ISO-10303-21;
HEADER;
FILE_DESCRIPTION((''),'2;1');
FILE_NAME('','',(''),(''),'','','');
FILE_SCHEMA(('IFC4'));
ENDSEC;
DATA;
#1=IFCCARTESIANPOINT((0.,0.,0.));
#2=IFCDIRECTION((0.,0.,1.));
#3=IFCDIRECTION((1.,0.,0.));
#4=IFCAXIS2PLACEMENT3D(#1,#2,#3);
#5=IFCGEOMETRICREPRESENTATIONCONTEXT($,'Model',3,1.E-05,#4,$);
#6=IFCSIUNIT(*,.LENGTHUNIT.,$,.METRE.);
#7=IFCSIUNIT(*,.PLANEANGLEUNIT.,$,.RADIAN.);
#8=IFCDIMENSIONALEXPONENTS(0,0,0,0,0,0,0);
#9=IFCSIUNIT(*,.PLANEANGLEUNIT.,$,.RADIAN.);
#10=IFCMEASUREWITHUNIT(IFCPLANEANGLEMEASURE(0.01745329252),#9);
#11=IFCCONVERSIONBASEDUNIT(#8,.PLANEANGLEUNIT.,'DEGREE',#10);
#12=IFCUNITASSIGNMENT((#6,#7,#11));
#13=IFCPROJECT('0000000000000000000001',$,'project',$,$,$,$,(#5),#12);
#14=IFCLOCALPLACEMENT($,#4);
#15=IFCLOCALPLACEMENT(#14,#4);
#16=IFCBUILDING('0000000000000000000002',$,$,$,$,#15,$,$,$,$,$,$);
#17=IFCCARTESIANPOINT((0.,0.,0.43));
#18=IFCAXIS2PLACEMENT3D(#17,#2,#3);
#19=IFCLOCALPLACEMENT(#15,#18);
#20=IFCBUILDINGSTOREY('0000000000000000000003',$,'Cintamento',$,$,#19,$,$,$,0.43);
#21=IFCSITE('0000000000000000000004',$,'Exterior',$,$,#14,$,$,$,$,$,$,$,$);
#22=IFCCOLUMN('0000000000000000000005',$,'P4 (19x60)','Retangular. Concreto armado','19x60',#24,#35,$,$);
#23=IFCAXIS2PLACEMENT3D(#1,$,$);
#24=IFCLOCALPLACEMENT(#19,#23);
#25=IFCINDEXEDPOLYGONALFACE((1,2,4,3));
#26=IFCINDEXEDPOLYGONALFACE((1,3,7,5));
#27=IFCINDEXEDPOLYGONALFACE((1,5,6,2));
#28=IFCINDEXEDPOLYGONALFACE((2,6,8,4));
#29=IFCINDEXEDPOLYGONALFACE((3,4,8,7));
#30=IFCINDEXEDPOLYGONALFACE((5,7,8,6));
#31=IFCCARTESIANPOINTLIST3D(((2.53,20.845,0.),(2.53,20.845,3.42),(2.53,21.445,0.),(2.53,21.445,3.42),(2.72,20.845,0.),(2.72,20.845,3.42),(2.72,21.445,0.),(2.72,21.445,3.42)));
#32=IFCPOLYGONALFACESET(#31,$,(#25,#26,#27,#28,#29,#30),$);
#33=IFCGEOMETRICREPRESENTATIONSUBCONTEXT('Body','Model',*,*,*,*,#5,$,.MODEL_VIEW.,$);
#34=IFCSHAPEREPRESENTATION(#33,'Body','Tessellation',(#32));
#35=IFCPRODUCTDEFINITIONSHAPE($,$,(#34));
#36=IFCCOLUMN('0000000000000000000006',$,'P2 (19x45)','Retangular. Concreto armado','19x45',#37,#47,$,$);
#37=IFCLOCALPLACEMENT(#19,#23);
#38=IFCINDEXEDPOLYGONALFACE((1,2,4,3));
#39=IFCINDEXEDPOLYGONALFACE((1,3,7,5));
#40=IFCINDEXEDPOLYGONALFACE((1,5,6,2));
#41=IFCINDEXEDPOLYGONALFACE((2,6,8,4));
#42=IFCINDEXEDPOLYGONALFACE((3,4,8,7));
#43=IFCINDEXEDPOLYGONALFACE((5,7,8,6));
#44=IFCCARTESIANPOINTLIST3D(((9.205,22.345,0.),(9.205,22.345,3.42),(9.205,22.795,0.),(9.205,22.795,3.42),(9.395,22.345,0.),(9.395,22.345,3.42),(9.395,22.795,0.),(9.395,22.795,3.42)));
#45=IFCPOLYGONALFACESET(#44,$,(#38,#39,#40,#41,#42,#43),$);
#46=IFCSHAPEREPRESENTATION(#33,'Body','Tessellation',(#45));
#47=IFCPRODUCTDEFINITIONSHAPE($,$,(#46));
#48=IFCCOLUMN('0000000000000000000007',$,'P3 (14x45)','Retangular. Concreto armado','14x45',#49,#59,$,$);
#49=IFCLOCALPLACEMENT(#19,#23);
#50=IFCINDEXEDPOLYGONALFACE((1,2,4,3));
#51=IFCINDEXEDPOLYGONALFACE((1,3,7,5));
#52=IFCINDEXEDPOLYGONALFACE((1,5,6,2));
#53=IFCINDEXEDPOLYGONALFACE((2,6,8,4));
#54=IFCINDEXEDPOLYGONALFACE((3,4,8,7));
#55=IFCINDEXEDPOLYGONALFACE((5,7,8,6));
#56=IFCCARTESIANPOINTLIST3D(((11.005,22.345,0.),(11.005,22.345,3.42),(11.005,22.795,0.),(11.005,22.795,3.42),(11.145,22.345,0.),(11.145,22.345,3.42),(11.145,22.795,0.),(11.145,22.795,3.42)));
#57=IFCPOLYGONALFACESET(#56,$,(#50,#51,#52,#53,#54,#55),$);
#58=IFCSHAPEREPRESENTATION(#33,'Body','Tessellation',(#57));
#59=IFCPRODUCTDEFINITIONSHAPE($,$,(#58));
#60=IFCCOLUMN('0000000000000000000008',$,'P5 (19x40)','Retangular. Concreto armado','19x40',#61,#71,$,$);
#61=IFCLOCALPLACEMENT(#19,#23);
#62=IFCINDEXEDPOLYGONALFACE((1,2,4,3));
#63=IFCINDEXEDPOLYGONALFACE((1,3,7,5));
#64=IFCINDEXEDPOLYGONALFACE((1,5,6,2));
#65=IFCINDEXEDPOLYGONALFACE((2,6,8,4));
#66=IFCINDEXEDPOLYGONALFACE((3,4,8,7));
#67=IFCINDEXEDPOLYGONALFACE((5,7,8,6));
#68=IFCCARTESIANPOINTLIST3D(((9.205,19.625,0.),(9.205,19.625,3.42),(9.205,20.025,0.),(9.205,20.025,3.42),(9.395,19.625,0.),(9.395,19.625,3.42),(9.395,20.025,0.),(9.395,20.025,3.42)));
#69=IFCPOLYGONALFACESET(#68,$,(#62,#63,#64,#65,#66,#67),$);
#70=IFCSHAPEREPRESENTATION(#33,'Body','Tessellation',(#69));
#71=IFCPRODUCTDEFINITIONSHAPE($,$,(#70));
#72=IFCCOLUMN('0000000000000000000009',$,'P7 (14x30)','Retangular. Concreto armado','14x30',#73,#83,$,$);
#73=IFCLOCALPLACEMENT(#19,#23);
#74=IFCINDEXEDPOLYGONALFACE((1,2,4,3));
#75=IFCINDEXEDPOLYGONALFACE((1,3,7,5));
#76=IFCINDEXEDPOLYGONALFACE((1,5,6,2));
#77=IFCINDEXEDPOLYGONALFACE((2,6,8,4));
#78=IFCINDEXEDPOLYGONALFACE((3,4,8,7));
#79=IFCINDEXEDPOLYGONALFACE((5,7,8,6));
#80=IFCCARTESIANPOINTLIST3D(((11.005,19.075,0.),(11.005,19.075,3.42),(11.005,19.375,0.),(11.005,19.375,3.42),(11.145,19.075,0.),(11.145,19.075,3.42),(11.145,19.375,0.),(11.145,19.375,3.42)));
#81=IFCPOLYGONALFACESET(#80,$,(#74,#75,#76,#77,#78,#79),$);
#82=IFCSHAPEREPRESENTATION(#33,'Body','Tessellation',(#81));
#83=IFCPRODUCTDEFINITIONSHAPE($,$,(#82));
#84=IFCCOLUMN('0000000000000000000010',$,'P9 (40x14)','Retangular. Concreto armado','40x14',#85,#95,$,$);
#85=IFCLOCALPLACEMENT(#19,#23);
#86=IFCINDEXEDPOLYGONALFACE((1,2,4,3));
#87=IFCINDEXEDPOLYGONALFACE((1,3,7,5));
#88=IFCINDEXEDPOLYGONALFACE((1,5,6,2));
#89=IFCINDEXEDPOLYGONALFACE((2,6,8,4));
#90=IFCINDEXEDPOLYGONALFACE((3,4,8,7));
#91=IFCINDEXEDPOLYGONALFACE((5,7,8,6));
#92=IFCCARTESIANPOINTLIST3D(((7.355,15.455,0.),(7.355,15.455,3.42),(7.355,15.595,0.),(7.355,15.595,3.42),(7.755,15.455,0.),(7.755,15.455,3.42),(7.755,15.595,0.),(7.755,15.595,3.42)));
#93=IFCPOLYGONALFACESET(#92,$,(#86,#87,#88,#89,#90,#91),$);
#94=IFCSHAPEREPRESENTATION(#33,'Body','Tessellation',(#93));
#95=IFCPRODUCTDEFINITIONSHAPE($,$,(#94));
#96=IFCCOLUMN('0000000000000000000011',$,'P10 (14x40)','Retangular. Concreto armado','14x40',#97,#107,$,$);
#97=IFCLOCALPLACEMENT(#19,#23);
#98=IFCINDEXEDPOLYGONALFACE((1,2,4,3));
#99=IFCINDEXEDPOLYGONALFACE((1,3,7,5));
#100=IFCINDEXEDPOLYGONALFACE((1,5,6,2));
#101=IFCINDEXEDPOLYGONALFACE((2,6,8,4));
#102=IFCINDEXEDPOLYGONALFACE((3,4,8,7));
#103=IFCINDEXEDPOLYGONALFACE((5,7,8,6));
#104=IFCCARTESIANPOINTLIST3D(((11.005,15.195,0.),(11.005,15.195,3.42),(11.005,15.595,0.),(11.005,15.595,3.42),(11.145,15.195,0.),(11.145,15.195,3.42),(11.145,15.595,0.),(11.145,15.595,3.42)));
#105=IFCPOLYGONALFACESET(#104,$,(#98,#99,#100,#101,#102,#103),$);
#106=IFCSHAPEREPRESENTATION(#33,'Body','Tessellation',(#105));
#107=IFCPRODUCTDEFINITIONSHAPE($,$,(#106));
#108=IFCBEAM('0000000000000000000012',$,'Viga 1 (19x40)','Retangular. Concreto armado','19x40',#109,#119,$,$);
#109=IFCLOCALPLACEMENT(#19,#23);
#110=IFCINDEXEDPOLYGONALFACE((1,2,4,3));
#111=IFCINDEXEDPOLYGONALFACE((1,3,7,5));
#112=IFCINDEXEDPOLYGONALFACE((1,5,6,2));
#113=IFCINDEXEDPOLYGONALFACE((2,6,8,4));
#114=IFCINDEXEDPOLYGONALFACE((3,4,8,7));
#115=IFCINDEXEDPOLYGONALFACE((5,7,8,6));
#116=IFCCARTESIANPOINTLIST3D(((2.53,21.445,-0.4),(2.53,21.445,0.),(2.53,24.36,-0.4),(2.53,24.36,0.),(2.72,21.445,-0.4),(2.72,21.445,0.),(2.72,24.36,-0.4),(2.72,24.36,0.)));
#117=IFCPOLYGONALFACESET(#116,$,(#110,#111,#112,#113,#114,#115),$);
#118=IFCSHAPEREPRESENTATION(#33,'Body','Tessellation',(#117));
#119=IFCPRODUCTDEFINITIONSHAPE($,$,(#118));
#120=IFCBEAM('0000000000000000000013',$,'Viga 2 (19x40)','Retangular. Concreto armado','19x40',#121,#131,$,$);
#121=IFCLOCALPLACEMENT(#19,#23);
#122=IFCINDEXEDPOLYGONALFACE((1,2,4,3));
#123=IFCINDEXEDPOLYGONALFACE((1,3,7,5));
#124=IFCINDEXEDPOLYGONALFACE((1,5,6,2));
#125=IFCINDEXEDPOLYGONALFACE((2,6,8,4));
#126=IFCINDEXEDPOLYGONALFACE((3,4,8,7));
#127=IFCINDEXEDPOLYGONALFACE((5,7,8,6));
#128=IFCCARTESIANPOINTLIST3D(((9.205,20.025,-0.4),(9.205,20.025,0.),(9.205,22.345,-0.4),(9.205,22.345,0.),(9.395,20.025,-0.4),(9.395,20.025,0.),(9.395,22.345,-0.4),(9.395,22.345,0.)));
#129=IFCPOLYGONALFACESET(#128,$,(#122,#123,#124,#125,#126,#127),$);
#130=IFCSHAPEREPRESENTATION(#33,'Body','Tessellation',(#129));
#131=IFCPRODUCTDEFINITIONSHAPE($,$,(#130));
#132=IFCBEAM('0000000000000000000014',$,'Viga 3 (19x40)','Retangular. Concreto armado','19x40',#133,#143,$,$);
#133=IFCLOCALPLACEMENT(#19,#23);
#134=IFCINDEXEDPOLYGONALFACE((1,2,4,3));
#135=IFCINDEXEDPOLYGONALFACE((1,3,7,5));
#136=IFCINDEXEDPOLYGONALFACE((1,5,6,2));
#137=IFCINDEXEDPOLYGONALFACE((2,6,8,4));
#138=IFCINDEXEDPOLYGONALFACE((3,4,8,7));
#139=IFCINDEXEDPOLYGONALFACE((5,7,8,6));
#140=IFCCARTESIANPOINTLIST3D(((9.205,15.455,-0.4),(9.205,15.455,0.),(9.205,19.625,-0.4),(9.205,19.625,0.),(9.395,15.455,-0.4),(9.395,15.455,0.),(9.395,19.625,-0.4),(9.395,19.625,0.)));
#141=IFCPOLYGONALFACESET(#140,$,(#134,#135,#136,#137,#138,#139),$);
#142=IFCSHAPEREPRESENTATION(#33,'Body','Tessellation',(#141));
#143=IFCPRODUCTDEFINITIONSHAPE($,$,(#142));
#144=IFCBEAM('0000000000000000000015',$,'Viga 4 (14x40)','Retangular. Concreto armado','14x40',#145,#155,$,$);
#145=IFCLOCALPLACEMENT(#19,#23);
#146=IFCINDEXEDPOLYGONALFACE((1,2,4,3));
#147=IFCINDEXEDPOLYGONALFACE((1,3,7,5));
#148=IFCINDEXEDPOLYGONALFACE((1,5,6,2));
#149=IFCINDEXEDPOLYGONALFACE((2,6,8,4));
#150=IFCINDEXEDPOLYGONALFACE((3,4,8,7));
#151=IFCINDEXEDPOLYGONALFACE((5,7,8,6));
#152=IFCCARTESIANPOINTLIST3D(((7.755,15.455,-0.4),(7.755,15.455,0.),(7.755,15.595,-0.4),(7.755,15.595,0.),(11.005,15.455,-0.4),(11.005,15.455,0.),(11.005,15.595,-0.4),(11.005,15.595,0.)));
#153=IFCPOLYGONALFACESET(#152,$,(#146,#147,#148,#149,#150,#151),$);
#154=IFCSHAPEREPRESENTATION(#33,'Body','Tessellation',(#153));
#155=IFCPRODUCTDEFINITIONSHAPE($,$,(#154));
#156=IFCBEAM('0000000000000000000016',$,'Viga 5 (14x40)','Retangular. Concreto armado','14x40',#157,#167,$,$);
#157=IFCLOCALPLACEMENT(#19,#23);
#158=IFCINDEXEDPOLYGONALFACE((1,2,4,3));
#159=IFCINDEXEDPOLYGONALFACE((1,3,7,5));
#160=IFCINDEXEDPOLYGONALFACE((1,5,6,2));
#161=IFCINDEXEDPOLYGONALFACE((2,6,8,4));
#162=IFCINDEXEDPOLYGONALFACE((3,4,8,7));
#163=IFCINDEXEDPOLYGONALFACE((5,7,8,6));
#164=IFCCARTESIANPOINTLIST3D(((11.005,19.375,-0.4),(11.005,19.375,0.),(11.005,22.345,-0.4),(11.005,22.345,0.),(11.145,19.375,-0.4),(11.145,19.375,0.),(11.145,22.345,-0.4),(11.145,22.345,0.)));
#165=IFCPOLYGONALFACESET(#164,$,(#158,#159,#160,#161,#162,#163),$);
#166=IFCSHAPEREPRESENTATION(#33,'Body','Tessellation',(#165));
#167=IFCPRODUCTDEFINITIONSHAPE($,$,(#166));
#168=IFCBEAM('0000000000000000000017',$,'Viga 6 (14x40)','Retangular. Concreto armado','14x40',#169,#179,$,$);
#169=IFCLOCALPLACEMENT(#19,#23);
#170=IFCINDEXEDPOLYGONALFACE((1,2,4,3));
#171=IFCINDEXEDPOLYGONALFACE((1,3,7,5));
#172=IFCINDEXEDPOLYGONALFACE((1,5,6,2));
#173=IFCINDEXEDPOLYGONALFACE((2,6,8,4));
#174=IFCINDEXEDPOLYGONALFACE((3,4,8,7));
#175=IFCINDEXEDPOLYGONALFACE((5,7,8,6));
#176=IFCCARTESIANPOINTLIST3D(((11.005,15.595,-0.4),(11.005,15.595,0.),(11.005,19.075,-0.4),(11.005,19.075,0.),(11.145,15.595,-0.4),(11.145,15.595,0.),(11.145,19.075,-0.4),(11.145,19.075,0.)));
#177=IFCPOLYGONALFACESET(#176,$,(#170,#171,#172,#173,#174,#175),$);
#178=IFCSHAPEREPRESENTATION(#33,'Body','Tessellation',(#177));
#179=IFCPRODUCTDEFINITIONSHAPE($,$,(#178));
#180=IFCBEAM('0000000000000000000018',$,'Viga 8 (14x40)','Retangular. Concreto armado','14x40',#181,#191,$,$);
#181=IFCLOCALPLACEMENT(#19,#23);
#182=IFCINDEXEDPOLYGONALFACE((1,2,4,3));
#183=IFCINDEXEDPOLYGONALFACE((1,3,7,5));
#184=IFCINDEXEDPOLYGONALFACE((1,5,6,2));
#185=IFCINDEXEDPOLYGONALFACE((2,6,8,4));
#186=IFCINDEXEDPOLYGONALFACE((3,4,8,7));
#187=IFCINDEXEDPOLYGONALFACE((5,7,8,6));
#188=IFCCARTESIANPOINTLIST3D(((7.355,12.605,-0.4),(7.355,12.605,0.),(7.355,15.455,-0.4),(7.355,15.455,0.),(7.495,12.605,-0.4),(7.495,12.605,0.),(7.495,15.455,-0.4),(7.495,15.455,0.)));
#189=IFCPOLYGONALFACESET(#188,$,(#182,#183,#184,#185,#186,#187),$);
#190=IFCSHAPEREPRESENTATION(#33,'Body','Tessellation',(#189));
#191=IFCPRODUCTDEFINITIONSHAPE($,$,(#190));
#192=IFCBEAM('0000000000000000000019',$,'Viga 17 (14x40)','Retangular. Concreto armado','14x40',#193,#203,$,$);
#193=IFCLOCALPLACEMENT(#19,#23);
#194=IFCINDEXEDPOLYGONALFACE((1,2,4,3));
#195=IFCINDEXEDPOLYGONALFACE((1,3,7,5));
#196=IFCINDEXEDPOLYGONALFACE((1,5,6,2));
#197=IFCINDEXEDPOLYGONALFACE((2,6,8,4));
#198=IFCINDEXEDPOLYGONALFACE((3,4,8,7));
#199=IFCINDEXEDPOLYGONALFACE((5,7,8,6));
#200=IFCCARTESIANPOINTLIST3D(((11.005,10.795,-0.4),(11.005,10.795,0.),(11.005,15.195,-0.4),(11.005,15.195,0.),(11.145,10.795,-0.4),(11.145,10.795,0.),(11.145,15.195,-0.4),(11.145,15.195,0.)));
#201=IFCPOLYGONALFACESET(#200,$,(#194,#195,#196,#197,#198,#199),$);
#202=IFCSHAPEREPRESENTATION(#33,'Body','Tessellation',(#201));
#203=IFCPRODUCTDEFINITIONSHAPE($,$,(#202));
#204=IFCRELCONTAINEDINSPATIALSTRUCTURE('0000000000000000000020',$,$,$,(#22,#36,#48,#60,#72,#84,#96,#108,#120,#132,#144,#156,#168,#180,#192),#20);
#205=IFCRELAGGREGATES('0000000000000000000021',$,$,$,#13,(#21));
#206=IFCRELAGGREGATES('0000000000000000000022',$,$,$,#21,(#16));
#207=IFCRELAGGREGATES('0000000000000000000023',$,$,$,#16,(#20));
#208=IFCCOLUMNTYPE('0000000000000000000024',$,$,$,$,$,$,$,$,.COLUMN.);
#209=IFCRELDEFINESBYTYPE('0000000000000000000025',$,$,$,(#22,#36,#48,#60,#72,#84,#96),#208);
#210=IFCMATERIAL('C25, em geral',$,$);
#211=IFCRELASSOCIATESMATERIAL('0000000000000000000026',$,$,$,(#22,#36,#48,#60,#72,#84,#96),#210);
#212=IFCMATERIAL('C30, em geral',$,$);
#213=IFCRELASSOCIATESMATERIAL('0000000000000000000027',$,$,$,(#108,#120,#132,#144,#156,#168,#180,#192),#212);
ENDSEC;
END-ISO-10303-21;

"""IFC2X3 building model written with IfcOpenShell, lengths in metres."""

from ifc_helpers import new_model, entity, si_unit, converted_unit, frame, frame_2d, origin_with_axes, place, context, subcontext, project, spatial, rectangle, extrude, material, type_object, element, save


model = new_model("IFC2X3")

# Units and contexts
model_context = context("Model", 3, precision=1e-05, world=origin_with_axes())
body_context = subcontext(model_context, "Body", "Model", "MODEL_VIEW")
ifc_project = project(units=[si_unit("LENGTHUNIT", "METRE"), si_unit("PLANEANGLEUNIT", "RADIAN"), converted_unit("PLANEANGLEUNIT", "DEGREE", entity("IfcPlaneAngleMeasure", 0.01745329252), si_unit("PLANEANGLEUNIT", "RADIAN"), dimensions=[0, 0, 0, 0, 0, 0, 0])], contexts=[model_context])

# Site, building, storey
site_placement = place(None, origin_with_axes())
site = spatial("IfcSite", under=ifc_project, at=site_placement, Name="Exterior")
building_placement = place(site_placement, origin_with_axes())
building = spatial("IfcBuilding", under=site, at=building_placement)
storey_placement = place(building_placement, frame((0.0, 0.0, 0.43), z_axis=(0.0, 0.0, 1.0), x_axis=(1.0, 0.0, 0.0)))
storey = spatial("IfcBuildingStorey", under=building, at=storey_placement, Name="Cintamento", Elevation=0.43)

# Columns
ifc_material_1 = material(Name="C25, em geral")
column_type = type_object("IfcColumnType", PredefinedType="COLUMN")
column_1_placement = place(storey_placement, frame((2.53, 21.445, 0.0), z_axis=(0.0, 0.0, 1.0), x_axis=(1.0, 0.0, 0.0)))
element("IfcColumn", 1, at=column_1_placement, inside=storey, type_object=column_type, material=ifc_material_1, Name="P4 (19x60)", Description="Retangular. Concreto armado", ObjectType="19x60", context=body_context, shape_type="SweptSolid", body=[
    extrude(rectangle(XDim=0.19, YDim=0.6, at=frame_2d((0.095, -0.3), x_axis=(1.0, 0.0))), origin_with_axes(), (0.0, 0.0, 1.0), 3.42),
])
column_2_placement = place(storey_placement, frame((9.395, 22.345, 0.0), z_axis=(0.0, 0.0, 1.0), x_axis=(1.0, 0.0, 0.0)))
element("IfcColumn", 2, at=column_2_placement, inside=storey, type_object=column_type, material=ifc_material_1, Name="P2 (19x45)", Description="Retangular. Concreto armado", ObjectType="19x45", context=body_context, shape_type="SweptSolid", body=[
    extrude(rectangle(XDim=0.19, YDim=0.45, at=frame_2d((-0.095, 0.225), x_axis=(1.0, 0.0))), origin_with_axes(), (0.0, 0.0, 1.0), 3.42),
])
column_3_placement = place(storey_placement, frame((11.145, 22.345, 0.0), z_axis=(0.0, 0.0, 1.0), x_axis=(1.0, 0.0, 0.0)))
element("IfcColumn", 3, at=column_3_placement, inside=storey, type_object=column_type, material=ifc_material_1, Name="P3 (14x45)", Description="Retangular. Concreto armado", ObjectType="14x45", context=body_context, shape_type="SweptSolid", body=[
    extrude(rectangle(XDim=0.14, YDim=0.45, at=frame_2d((-0.07, 0.225), x_axis=(1.0, 0.0))), origin_with_axes(), (0.0, 0.0, 1.0), 3.42),
])
column_4_placement = place(storey_placement, frame((9.395, 19.625, 0.0), z_axis=(0.0, 0.0, 1.0), x_axis=(1.0, 0.0, 0.0)))
element("IfcColumn", 4, at=column_4_placement, inside=storey, type_object=column_type, material=ifc_material_1, Name="P5 (19x40)", Description="Retangular. Concreto armado", ObjectType="19x40", context=body_context, shape_type="SweptSolid", body=[
    extrude(rectangle(XDim=0.19, YDim=0.4, at=frame_2d((-0.095, 0.2), x_axis=(1.0, 0.0))), origin_with_axes(), (0.0, 0.0, 1.0), 3.42),
])
column_5_placement = place(storey_placement, frame((11.005, 19.375, 0.0), z_axis=(0.0, 0.0, 1.0), x_axis=(1.0, 0.0, 0.0)))
element("IfcColumn", 5, at=column_5_placement, inside=storey, type_object=column_type, material=ifc_material_1, Name="P7 (14x30)", Description="Retangular. Concreto armado", ObjectType="14x30", context=body_context, shape_type="SweptSolid", body=[
    extrude(rectangle(XDim=0.14, YDim=0.3, at=frame_2d((0.07, -0.15), x_axis=(1.0, 0.0))), origin_with_axes(), (0.0, 0.0, 1.0), 3.42),
])
column_6_placement = place(storey_placement, frame((7.355, 15.455, 0.0), z_axis=(0.0, 0.0, 1.0), x_axis=(1.0, 0.0, 0.0)))
element("IfcColumn", 6, at=column_6_placement, inside=storey, type_object=column_type, material=ifc_material_1, Name="P9 (40x14)", Description="Retangular. Concreto armado", ObjectType="40x14", context=body_context, shape_type="SweptSolid", body=[
    extrude(rectangle(XDim=0.4, YDim=0.14, at=frame_2d((0.2, 0.07), x_axis=(1.0, 0.0))), origin_with_axes(), (0.0, 0.0, 1.0), 3.42),
])
column_7_placement = place(storey_placement, frame((11.145, 15.595, 0.0), z_axis=(0.0, 0.0, 1.0), x_axis=(1.0, 0.0, 0.0)))
element("IfcColumn", 7, at=column_7_placement, inside=storey, type_object=column_type, material=ifc_material_1, Name="P10 (14x40)", Description="Retangular. Concreto armado", ObjectType="14x40", context=body_context, shape_type="SweptSolid", body=[
    extrude(rectangle(XDim=0.14, YDim=0.4, at=frame_2d((-0.07, -0.2), x_axis=(1.0, 0.0))), origin_with_axes(), (0.0, 0.0, 1.0), 3.42),
])

# Beams
ifc_material_2 = material(Name="C30, em geral")
beam_1_placement = place(storey_placement, frame((2.625, 21.445, 0.0), z_axis=(0.0, 1.0, 0.0), x_axis=(-1.0, 0.0, 0.0)))
element("IfcBeam", 8, at=beam_1_placement, inside=storey, material=ifc_material_2, Name="Viga 1 (19x40)", Description="Retangular. Concreto armado", ObjectType="19x40", context=body_context, shape_type="SweptSolid", body=[
    extrude(rectangle(XDim=0.19, YDim=0.4, at=frame_2d((0.0, -0.2), x_axis=(1.0, 0.0))), origin_with_axes(), (0.0, 0.0, 1.0), 2.915),
])
beam_2_placement = place(storey_placement, frame((9.3, 22.345, 0.0), z_axis=(0.0, -1.0, 0.0), x_axis=(1.0, 0.0, 0.0)))
element("IfcBeam", 9, at=beam_2_placement, inside=storey, material=ifc_material_2, Name="Viga 2 (19x40)", Description="Retangular. Concreto armado", ObjectType="19x40", context=body_context, shape_type="SweptSolid", body=[
    extrude(rectangle(XDim=0.19, YDim=0.4, at=frame_2d((0.0, -0.2), x_axis=(1.0, 0.0))), origin_with_axes(), (0.0, 0.0, 1.0), 2.32),
])
beam_3_placement = place(storey_placement, frame((9.3, 19.625, 0.0), z_axis=(0.0, -1.0, 0.0), x_axis=(1.0, 0.0, 0.0)))
element("IfcBeam", 10, at=beam_3_placement, inside=storey, material=ifc_material_2, Name="Viga 3 (19x40)", Description="Retangular. Concreto armado", ObjectType="19x40", context=body_context, shape_type="SweptSolid", body=[
    extrude(rectangle(XDim=0.19, YDim=0.4, at=frame_2d((0.0, -0.2), x_axis=(1.0, 0.0))), origin_with_axes(), (0.0, 0.0, 1.0), 4.17),
])
beam_4_placement = place(storey_placement, frame((7.755, 15.525, 0.0), z_axis=(1.0, 0.0, 0.0), x_axis=(0.0, 1.0, 0.0)))
element("IfcBeam", 11, at=beam_4_placement, inside=storey, material=ifc_material_2, Name="Viga 4 (14x40)", Description="Retangular. Concreto armado", ObjectType="14x40", context=body_context, shape_type="SweptSolid", body=[
    extrude(rectangle(XDim=0.14, YDim=0.4, at=frame_2d((0.0, -0.2), x_axis=(1.0, 0.0))), origin_with_axes(), (0.0, 0.0, 1.0), 3.25),
])
beam_5_placement = place(storey_placement, frame((11.075, 22.345, 0.0), z_axis=(0.0, -1.0, 0.0), x_axis=(1.0, 0.0, 0.0)))
element("IfcBeam", 12, at=beam_5_placement, inside=storey, material=ifc_material_2, Name="Viga 5 (14x40)", Description="Retangular. Concreto armado", ObjectType="14x40", context=body_context, shape_type="SweptSolid", body=[
    extrude(rectangle(XDim=0.14, YDim=0.4, at=frame_2d((0.0, -0.2), x_axis=(1.0, 0.0))), origin_with_axes(), (0.0, 0.0, 1.0), 2.97),
])
beam_6_placement = place(storey_placement, frame((11.075, 19.075, 0.0), z_axis=(0.0, -1.0, 0.0), x_axis=(1.0, 0.0, 0.0)))
element("IfcBeam", 13, at=beam_6_placement, inside=storey, material=ifc_material_2, Name="Viga 6 (14x40)", Description="Retangular. Concreto armado", ObjectType="14x40", context=body_context, shape_type="SweptSolid", body=[
    extrude(rectangle(XDim=0.14, YDim=0.4, at=frame_2d((0.0, -0.2), x_axis=(1.0, 0.0))), origin_with_axes(), (0.0, 0.0, 1.0), 3.48),
])
beam_7_placement = place(storey_placement, frame((7.425, 15.455, 0.0), z_axis=(0.0, -1.0, 0.0), x_axis=(1.0, 0.0, 0.0)))
element("IfcBeam", 14, at=beam_7_placement, inside=storey, material=ifc_material_2, Name="Viga 8 (14x40)", Description="Retangular. Concreto armado", ObjectType="14x40", context=body_context, shape_type="SweptSolid", body=[
    extrude(rectangle(XDim=0.14, YDim=0.4, at=frame_2d((0.0, -0.2), x_axis=(1.0, 0.0))), origin_with_axes(), (0.0, 0.0, 1.0), 2.85),
])
beam_8_placement = place(storey_placement, frame((11.075, 15.195, 0.0), z_axis=(0.0, -1.0, 0.0), x_axis=(1.0, 0.0, 0.0)))
element("IfcBeam", 15, at=beam_8_placement, inside=storey, material=ifc_material_2, Name="Viga 17 (14x40)", Description="Retangular. Concreto armado", ObjectType="14x40", context=body_context, shape_type="SweptSolid", body=[
    extrude(rectangle(XDim=0.14, YDim=0.4, at=frame_2d((0.0, -0.2), x_axis=(1.0, 0.0))), origin_with_axes(), (0.0, 0.0, 1.0), 4.4),
])

save(model, "model.ifc")
